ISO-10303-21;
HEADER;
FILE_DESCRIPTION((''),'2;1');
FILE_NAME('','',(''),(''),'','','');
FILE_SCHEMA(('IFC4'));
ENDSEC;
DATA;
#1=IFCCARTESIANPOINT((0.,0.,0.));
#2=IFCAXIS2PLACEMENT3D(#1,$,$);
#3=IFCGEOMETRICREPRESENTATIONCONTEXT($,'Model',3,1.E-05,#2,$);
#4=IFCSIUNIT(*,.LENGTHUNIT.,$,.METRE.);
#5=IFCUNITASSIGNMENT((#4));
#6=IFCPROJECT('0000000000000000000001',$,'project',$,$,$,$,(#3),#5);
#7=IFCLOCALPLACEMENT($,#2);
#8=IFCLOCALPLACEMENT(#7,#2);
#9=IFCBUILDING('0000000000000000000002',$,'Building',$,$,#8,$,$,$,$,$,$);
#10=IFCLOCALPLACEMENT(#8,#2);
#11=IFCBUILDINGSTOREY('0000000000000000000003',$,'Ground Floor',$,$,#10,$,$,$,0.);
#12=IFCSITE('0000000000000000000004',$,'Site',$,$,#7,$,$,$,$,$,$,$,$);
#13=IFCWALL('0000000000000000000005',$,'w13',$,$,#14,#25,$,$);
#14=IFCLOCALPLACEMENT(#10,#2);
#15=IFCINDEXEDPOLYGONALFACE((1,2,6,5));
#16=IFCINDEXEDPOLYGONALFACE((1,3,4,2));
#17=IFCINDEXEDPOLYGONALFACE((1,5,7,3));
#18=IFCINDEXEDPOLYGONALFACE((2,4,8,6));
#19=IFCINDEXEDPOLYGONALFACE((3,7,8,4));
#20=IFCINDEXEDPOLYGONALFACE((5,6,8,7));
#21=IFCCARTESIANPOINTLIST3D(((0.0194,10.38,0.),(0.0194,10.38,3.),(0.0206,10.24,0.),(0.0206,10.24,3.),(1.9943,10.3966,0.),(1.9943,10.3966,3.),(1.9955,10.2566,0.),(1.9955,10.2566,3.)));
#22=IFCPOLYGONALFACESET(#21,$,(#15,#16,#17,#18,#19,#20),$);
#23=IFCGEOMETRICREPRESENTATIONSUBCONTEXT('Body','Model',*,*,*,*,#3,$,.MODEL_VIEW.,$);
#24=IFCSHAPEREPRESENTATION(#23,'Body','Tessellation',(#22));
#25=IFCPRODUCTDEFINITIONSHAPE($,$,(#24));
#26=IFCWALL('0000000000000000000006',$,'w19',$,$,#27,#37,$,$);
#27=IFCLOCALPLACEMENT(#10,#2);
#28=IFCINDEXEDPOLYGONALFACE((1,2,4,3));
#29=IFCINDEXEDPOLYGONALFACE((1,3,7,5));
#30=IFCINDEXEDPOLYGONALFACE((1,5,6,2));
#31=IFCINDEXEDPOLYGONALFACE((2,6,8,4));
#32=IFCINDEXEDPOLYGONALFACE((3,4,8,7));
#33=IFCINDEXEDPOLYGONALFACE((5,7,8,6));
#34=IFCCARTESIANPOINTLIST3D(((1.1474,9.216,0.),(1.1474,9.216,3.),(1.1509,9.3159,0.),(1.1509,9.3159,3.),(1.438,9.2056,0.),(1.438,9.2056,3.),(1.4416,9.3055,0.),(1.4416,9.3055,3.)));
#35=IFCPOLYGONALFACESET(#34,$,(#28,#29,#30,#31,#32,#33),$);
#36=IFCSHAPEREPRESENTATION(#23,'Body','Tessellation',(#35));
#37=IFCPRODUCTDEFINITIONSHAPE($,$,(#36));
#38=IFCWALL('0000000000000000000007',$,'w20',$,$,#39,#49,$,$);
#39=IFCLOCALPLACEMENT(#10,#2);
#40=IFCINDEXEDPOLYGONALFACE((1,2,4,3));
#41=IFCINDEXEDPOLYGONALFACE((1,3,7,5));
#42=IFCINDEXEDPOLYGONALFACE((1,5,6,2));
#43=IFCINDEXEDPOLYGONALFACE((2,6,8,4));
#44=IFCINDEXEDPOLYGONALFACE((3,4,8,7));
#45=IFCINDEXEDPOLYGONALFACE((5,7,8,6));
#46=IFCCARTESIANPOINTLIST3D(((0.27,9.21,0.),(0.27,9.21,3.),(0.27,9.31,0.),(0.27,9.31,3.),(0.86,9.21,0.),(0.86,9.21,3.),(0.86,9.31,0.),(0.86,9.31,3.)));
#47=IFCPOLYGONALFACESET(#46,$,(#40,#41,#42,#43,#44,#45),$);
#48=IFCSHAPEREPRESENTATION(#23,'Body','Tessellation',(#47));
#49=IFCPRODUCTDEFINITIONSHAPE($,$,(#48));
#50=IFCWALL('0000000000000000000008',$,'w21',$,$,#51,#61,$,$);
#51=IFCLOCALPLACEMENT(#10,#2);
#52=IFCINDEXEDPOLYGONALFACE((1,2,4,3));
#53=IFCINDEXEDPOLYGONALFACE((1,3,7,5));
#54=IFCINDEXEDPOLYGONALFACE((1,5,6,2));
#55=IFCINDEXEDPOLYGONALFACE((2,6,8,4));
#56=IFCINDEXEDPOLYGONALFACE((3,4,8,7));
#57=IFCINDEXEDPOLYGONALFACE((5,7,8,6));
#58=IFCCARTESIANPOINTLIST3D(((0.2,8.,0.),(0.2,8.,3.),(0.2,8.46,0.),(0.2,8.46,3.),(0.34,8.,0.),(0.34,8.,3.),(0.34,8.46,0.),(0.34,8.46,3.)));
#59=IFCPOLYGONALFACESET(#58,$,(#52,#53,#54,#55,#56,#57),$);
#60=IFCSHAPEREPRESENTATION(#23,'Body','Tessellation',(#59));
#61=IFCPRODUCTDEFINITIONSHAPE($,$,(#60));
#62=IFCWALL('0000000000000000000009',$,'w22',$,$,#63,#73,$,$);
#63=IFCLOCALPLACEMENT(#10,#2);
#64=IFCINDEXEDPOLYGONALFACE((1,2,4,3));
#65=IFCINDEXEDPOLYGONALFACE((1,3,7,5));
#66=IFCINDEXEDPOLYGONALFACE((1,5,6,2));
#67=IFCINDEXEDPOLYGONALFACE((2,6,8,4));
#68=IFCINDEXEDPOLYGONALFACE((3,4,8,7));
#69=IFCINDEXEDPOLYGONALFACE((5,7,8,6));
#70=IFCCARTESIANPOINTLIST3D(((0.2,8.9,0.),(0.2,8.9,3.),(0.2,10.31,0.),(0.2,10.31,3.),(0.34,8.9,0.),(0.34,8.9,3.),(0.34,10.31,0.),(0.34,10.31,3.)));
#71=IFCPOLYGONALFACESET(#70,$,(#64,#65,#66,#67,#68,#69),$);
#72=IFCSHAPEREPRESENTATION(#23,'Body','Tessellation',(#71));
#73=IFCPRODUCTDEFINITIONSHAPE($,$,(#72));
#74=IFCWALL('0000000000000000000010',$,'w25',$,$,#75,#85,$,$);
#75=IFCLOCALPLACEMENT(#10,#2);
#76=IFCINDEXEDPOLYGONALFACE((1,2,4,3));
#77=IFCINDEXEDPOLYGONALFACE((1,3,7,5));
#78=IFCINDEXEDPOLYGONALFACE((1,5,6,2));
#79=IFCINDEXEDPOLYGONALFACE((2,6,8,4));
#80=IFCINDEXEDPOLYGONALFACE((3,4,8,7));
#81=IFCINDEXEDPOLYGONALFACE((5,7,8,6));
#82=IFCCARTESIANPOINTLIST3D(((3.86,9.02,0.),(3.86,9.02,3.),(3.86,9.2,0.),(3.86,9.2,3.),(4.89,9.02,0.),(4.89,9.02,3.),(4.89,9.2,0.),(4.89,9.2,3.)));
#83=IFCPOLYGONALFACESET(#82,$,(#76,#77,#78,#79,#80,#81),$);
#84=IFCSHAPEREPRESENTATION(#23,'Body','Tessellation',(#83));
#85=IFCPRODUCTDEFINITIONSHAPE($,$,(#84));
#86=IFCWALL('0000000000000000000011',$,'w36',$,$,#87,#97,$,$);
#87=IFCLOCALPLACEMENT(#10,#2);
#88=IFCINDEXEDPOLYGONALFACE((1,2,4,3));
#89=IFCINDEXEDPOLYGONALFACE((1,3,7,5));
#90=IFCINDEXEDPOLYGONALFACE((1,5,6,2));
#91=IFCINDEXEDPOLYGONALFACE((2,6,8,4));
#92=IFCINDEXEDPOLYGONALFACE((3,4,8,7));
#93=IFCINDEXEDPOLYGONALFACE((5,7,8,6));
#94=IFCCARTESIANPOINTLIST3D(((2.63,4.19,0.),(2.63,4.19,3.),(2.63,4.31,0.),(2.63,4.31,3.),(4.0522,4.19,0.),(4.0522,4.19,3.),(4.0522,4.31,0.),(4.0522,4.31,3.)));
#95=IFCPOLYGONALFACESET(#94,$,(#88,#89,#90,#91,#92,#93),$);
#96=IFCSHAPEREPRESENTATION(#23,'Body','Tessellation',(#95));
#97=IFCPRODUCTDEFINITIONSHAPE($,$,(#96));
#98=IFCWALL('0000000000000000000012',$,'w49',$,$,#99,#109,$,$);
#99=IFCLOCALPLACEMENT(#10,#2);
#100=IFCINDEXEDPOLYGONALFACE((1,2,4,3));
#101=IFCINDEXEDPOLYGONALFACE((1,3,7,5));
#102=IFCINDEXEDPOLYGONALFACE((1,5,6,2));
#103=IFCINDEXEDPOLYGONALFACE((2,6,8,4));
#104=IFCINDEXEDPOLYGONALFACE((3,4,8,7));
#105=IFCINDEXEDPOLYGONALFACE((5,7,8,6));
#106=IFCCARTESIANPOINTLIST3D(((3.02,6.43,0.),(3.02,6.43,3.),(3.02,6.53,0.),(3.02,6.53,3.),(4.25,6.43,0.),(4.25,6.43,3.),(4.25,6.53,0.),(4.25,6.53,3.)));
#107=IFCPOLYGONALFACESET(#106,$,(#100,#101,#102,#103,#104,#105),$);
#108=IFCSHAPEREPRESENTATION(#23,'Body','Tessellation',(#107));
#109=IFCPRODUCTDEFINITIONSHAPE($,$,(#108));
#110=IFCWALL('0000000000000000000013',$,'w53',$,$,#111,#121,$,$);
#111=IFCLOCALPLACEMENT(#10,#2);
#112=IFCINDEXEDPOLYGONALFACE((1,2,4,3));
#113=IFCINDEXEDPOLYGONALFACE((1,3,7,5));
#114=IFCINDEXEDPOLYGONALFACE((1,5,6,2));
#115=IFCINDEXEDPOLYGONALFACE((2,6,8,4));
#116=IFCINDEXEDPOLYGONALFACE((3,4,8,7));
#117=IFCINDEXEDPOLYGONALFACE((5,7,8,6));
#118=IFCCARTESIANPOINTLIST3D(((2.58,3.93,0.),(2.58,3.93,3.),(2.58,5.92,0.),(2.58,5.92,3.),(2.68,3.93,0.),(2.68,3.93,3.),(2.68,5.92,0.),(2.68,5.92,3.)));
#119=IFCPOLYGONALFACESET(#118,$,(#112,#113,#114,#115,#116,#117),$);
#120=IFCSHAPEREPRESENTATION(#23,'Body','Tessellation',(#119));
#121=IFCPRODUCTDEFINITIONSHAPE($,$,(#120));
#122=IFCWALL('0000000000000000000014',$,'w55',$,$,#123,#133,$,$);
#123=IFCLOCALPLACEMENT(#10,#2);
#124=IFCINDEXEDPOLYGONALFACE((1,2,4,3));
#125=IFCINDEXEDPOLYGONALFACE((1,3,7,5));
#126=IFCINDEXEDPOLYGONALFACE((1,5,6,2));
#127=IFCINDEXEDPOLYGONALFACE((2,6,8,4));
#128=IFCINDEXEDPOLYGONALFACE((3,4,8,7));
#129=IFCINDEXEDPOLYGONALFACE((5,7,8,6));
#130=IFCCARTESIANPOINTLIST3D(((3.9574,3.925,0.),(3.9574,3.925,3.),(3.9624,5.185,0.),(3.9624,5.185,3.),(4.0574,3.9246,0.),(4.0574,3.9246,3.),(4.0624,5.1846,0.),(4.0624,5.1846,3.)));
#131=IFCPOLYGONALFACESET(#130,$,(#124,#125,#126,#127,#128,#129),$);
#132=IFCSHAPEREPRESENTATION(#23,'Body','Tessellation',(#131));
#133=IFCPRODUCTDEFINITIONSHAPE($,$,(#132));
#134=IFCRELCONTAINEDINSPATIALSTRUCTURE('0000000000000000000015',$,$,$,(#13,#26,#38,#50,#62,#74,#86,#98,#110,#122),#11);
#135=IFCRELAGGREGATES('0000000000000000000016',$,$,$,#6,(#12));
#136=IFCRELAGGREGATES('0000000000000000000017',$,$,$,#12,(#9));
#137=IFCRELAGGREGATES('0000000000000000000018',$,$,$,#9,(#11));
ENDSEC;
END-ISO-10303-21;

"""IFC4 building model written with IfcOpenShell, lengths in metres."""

from ifc_helpers import new_model, si_unit, frame, origin, place, context, subcontext, project, spatial, polyline, outline, extrude, element, save


model = new_model("IFC4")

# Units and contexts
model_context = context("Model", 3, precision=1e-05, world=origin())
body_context = subcontext(model_context, "Body", "Model", "MODEL_VIEW")
ifc_project = project(units=[si_unit("LENGTHUNIT", "METRE")], contexts=[model_context])

# Site, building, storey
site_placement = place(None, origin())
site = spatial("IfcSite", under=ifc_project, at=site_placement, Name="Site")
building_placement = place(site_placement, origin())
building = spatial("IfcBuilding", under=site, at=building_placement, Name="Building")
storey_placement = place(building_placement, origin())
storey = spatial("IfcBuildingStorey", under=building, at=storey_placement, Name="Ground Floor", Elevation=0.0)

# Walls
wall_1_placement = place(storey_placement, frame((0.02, 10.31, 0.0), x_axis=(0.999965, 0.008424, 0.0)))
element("IfcWall", 1, at=wall_1_placement, inside=storey, Name="w13", context=body_context, shape_type="SweptSolid", body=[
    extrude(outline(polyline([(0.0, -0.07), (1.9749, -0.07), (1.9749, 0.07), (0.0, 0.07), (0.0, -0.07)])), origin(), (0.0, 0.0, 1.0), 3.0),
])
wall_2_placement = place(storey_placement, frame((1.1491, 9.2659, 0.0), x_axis=(0.999363, -0.035694, 0.0)))
element("IfcWall", 2, at=wall_2_placement, inside=storey, Name="w19", context=body_context, shape_type="SweptSolid", body=[
    extrude(outline(polyline([(0.0, -0.05), (0.2909, -0.05), (0.2909, 0.05), (0.0, 0.05), (0.0, -0.05)])), origin(), (0.0, 0.0, 1.0), 3.0),
])
wall_3_placement = place(storey_placement, frame((0.27, 9.26, 0.0), x_axis=(1.0, 0.0, 0.0)))
element("IfcWall", 3, at=wall_3_placement, inside=storey, Name="w20", context=body_context, shape_type="SweptSolid", body=[
    extrude(outline(polyline([(0.0, -0.05), (0.59, -0.05), (0.59, 0.05), (0.0, 0.05), (0.0, -0.05)])), origin(), (0.0, 0.0, 1.0), 3.0),
])
wall_4_placement = place(storey_placement, frame((0.27, 8.0, 0.0), x_axis=(0.0, 1.0, 0.0)))
element("IfcWall", 4, at=wall_4_placement, inside=storey, Name="w21", context=body_context, shape_type="SweptSolid", body=[
    extrude(outline(polyline([(0.0, -0.07), (0.46, -0.07), (0.46, 0.07), (0.0, 0.07), (0.0, -0.07)])), origin(), (0.0, 0.0, 1.0), 3.0),
])
wall_5_placement = place(storey_placement, frame((0.27, 8.9, 0.0), x_axis=(0.0, 1.0, 0.0)))
element("IfcWall", 5, at=wall_5_placement, inside=storey, Name="w22", context=body_context, shape_type="SweptSolid", body=[
    extrude(outline(polyline([(0.0, -0.07), (1.41, -0.07), (1.41, 0.07), (0.0, 0.07), (0.0, -0.07)])), origin(), (0.0, 0.0, 1.0), 3.0),
])
wall_6_placement = place(storey_placement, frame((3.86, 9.11, 0.0), x_axis=(1.0, 0.0, 0.0)))
element("IfcWall", 6, at=wall_6_placement, inside=storey, Name="w25", context=body_context, shape_type="SweptSolid", body=[
    extrude(outline(polyline([(0.0, -0.09), (1.03, -0.09), (1.03, 0.09), (0.0, 0.09), (0.0, -0.09)])), origin(), (0.0, 0.0, 1.0), 3.0),
])
wall_7_placement = place(storey_placement, frame((2.63, 4.25, 0.0), x_axis=(1.0, 0.0, 0.0)))
element("IfcWall", 7, at=wall_7_placement, inside=storey, Name="w36", context=body_context, shape_type="SweptSolid", body=[
    extrude(outline(polyline([(0.0, -0.06), (1.4222, -0.06), (1.4222, 0.06), (0.0, 0.06), (0.0, -0.06)])), origin(), (0.0, 0.0, 1.0), 3.0),
])
wall_8_placement = place(storey_placement, frame((3.02, 6.48, 0.0), x_axis=(1.0, 0.0, 0.0)))
element("IfcWall", 8, at=wall_8_placement, inside=storey, Name="w49", context=body_context, shape_type="SweptSolid", body=[
    extrude(outline(polyline([(0.0, -0.05), (1.23, -0.05), (1.23, 0.05), (0.0, 0.05), (0.0, -0.05)])), origin(), (0.0, 0.0, 1.0), 3.0),
])
wall_9_placement = place(storey_placement, frame((2.63, 3.93, 0.0), x_axis=(0.0, 1.0, 0.0)))
element("IfcWall", 9, at=wall_9_placement, inside=storey, Name="w53", context=body_context, shape_type="SweptSolid", body=[
    extrude(outline(polyline([(0.0, -0.05), (1.99, -0.05), (1.99, 0.05), (0.0, 0.05), (0.0, -0.05)])), origin(), (0.0, 0.0, 1.0), 3.0),
])
wall_10_placement = place(storey_placement, frame((4.0074, 3.9248, 0.0), x_axis=(0.003968, 0.999992, 0.0)))
element("IfcWall", 10, at=wall_10_placement, inside=storey, Name="w55", context=body_context, shape_type="SweptSolid", body=[
    extrude(outline(polyline([(0.0, -0.05), (1.26, -0.05), (1.26, 0.05), (0.0, 0.05), (0.0, -0.05)])), origin(), (0.0, 0.0, 1.0), 3.0),
])

save(model, "model.ifc")
